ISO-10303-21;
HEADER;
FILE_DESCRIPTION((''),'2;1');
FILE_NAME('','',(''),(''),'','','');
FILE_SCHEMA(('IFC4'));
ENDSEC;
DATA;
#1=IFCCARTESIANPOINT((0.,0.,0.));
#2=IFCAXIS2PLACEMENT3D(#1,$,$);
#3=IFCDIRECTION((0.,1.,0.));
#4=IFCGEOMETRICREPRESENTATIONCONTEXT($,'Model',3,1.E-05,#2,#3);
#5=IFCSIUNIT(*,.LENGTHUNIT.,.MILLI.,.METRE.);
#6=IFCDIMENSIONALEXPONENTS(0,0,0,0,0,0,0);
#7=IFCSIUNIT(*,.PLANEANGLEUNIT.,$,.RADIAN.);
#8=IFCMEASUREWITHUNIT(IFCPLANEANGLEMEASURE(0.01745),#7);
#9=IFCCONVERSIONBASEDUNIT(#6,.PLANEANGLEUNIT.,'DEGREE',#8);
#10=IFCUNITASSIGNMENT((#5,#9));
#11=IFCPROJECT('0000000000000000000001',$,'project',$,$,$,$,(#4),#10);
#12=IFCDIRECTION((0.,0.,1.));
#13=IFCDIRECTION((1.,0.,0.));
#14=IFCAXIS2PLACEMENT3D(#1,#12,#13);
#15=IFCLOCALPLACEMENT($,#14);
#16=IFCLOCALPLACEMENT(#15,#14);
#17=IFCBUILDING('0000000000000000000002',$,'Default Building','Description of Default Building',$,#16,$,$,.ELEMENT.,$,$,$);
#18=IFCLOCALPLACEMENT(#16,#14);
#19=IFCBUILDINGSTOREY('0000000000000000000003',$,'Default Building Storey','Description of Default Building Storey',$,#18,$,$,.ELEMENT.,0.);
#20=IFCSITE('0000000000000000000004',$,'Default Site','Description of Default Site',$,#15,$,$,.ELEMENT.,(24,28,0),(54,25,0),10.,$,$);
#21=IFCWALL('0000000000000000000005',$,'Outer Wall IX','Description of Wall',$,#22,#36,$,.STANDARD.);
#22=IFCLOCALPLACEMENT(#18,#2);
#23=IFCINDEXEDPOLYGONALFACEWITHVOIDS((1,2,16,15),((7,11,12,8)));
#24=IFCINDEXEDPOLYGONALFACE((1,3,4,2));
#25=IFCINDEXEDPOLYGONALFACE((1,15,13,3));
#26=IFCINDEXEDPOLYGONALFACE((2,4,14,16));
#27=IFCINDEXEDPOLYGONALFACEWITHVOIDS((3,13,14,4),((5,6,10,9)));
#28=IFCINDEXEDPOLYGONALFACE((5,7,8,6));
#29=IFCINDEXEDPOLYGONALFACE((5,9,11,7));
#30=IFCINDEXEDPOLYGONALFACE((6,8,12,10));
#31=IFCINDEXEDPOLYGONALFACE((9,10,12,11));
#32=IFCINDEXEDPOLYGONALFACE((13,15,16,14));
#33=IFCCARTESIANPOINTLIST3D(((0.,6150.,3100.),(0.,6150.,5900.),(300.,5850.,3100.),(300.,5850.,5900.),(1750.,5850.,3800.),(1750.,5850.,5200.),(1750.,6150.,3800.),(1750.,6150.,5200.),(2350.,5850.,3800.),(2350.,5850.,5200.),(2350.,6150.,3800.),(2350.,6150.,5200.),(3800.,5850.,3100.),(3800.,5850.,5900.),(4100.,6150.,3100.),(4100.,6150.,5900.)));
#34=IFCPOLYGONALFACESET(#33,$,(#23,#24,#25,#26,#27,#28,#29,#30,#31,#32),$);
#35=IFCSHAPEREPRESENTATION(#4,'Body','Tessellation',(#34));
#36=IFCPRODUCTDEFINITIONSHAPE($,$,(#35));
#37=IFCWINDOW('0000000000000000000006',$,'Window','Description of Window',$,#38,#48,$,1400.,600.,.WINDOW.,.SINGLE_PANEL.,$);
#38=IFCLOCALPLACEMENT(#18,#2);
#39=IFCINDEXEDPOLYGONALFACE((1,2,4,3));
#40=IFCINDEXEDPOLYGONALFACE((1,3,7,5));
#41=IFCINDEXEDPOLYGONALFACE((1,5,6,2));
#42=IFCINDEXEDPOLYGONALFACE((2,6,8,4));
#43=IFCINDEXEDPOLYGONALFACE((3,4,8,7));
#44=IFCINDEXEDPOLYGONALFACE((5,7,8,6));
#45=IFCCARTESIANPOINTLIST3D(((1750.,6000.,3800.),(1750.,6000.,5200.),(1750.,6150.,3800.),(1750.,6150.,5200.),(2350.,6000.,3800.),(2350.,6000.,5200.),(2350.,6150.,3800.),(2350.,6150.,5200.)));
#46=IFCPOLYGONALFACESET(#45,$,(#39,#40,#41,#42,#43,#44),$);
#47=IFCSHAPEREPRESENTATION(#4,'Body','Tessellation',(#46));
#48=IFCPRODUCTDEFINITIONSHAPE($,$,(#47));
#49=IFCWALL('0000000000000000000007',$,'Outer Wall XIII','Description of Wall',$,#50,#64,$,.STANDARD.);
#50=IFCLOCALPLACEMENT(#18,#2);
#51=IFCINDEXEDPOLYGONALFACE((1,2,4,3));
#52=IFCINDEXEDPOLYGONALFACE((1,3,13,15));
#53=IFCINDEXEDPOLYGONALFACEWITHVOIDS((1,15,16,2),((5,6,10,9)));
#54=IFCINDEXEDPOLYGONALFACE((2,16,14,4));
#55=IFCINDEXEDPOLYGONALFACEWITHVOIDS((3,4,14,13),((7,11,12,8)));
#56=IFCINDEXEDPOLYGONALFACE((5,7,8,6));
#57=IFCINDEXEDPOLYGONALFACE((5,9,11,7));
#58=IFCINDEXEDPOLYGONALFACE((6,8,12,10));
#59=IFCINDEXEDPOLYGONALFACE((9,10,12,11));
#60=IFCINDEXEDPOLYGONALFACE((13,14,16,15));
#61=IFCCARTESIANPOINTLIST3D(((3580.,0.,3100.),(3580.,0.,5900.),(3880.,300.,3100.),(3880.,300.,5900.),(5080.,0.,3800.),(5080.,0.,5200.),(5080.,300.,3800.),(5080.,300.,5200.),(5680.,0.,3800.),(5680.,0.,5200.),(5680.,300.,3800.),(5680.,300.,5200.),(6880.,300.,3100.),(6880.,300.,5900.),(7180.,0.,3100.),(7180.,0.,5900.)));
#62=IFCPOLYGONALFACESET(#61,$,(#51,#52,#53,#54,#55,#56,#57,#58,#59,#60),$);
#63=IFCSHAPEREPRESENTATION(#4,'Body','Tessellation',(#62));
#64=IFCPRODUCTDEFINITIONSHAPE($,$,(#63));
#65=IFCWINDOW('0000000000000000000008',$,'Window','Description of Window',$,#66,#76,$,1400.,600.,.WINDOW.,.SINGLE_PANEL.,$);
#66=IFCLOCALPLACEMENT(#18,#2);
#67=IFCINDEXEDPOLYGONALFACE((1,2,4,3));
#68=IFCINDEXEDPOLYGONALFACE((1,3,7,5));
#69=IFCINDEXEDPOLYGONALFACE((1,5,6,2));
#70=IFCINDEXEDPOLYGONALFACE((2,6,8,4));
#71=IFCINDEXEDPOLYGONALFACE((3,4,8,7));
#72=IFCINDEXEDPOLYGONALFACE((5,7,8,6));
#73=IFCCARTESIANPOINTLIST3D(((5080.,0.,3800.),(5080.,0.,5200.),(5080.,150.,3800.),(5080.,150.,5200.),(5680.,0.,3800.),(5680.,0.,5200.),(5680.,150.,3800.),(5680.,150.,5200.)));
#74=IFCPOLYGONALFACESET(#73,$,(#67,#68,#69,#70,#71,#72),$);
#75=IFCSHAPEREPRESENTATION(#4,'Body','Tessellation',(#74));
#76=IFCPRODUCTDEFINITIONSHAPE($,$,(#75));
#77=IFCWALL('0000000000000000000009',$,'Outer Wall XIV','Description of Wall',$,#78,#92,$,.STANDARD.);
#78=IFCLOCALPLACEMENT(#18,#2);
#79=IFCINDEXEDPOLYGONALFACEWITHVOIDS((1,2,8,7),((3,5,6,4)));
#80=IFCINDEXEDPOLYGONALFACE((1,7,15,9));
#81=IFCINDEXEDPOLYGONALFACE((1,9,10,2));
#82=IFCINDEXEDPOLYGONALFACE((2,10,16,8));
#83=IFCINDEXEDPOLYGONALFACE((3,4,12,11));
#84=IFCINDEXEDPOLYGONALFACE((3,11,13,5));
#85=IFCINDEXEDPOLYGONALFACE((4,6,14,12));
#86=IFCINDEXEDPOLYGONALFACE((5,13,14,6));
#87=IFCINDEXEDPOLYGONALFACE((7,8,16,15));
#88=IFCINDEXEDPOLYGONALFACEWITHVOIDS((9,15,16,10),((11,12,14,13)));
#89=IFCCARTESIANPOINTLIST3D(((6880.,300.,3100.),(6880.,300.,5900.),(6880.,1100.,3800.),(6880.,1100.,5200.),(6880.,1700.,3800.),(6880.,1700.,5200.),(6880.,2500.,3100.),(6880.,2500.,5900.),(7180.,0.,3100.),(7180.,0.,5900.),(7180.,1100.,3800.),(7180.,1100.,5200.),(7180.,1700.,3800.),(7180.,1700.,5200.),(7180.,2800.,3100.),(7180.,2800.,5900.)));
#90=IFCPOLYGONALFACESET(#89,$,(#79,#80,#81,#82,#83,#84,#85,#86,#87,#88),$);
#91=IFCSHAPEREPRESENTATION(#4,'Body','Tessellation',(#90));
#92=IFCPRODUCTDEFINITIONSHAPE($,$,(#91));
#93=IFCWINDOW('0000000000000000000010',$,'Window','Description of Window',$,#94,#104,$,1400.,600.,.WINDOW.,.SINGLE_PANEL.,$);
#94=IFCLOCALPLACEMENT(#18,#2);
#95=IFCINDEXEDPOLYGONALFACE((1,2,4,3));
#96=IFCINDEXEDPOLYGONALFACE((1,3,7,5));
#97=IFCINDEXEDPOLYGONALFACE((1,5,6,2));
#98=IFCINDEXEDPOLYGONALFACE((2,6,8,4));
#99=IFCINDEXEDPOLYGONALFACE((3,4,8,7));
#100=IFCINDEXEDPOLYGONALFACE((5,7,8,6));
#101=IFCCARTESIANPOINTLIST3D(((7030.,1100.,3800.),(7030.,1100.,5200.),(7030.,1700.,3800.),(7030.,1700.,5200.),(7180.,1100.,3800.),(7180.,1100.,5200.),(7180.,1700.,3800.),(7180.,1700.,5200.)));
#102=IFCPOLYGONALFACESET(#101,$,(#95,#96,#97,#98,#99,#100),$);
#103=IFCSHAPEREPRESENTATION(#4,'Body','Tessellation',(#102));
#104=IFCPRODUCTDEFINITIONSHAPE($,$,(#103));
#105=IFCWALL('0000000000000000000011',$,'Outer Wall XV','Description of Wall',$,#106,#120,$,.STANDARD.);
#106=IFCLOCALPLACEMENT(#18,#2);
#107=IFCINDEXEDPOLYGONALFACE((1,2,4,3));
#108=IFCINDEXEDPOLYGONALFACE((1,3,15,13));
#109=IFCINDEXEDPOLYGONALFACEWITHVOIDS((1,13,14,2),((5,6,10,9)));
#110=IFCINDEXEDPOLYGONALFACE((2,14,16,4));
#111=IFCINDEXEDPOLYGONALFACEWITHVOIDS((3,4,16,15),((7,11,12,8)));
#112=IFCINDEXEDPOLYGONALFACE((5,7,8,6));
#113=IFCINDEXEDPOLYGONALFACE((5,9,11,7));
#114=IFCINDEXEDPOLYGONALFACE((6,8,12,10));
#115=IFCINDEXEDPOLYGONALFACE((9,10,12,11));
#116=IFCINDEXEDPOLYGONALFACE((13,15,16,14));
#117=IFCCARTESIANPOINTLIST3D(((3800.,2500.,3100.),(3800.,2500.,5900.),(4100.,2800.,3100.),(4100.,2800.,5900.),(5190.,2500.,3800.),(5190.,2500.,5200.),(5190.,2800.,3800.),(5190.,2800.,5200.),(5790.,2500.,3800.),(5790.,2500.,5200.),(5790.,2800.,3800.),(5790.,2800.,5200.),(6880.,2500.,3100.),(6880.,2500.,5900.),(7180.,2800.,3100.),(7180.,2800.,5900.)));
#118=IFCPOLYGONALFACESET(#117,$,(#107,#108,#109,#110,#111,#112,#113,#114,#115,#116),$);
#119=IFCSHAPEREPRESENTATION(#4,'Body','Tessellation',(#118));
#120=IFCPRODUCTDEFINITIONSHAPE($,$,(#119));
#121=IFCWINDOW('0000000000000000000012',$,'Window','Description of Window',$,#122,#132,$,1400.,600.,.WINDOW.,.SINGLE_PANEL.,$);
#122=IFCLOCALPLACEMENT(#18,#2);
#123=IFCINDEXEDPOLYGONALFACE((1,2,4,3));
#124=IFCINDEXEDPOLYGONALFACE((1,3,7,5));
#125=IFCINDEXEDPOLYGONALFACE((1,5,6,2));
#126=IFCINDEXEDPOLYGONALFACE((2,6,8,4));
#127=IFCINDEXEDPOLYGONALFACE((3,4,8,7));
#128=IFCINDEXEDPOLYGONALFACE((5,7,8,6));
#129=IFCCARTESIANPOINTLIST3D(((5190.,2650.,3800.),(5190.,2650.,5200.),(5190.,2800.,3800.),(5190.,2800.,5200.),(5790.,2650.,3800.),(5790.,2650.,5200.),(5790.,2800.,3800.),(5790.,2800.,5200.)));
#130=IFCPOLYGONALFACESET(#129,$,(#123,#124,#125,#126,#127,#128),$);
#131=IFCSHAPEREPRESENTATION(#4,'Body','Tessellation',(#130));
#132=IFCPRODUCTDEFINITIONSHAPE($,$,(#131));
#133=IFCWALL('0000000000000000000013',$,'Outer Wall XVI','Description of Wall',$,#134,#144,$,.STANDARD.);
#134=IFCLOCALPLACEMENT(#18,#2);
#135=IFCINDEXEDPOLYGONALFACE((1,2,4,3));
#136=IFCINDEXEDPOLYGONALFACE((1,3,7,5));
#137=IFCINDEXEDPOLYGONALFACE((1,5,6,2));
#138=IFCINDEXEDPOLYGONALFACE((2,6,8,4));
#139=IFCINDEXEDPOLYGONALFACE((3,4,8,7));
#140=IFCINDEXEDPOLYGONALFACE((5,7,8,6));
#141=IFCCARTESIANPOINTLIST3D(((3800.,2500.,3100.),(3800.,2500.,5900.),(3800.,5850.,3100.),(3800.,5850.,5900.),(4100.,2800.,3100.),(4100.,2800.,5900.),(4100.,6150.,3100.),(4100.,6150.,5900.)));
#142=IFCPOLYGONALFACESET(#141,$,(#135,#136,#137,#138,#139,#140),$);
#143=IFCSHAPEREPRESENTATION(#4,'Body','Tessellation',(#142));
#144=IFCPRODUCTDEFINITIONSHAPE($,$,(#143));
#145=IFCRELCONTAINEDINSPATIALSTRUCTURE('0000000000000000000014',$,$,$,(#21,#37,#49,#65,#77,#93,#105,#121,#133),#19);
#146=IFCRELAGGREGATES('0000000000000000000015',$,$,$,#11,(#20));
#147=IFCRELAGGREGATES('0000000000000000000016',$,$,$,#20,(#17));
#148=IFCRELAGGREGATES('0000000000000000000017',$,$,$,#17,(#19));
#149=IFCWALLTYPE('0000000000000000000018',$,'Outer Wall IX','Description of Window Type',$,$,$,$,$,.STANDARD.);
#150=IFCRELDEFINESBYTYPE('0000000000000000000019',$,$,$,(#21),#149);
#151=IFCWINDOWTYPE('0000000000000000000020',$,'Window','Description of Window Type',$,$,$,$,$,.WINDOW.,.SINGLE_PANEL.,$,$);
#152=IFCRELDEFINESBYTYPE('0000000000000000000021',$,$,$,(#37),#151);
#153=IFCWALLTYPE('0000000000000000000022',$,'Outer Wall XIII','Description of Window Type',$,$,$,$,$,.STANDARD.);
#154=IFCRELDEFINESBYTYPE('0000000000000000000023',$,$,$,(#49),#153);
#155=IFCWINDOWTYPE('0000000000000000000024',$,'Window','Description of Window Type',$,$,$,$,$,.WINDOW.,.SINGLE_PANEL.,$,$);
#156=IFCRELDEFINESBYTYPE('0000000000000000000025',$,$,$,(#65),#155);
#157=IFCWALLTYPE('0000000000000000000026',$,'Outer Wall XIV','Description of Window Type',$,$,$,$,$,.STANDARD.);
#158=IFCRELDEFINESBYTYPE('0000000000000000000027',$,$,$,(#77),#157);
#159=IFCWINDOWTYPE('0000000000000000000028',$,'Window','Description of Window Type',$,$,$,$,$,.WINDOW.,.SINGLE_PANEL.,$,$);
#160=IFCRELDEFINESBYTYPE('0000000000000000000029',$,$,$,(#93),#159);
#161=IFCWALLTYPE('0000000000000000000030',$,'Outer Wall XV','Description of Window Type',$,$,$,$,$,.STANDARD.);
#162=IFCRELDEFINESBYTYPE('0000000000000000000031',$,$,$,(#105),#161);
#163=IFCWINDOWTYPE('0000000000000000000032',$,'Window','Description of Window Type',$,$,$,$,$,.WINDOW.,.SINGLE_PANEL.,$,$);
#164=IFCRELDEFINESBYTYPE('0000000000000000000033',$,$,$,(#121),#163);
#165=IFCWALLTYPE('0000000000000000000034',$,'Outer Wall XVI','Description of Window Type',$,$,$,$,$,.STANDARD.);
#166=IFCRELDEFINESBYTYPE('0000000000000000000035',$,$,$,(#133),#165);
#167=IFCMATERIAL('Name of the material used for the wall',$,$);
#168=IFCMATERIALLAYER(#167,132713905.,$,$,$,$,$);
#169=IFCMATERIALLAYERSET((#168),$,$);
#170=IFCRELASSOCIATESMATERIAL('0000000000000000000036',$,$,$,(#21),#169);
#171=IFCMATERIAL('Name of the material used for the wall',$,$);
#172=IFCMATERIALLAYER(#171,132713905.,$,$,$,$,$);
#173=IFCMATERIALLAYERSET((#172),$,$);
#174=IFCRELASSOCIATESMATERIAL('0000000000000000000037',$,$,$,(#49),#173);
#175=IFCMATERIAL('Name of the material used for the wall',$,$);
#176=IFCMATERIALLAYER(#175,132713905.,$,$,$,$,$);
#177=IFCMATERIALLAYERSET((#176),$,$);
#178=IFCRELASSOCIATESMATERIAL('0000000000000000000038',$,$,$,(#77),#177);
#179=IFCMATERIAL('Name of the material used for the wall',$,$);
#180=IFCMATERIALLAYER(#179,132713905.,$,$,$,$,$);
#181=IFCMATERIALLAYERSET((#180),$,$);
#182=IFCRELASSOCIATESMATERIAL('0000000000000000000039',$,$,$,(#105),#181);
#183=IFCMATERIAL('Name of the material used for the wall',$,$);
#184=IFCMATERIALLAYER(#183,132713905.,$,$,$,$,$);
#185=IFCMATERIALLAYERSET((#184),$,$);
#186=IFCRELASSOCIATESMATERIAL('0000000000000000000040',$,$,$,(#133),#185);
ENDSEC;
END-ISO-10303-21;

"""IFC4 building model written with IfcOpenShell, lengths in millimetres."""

from ifc_helpers import new_model, entity, si_unit, converted_unit, direction, frame, origin, origin_with_axes, place, context, project, spatial, polyline, outline, extrude, material, layer, layer_set, layer_usage, type_object, element, fill, save


model = new_model("IFC4")

# Units and contexts
model_context = context("Model", 3, precision=1e-05, world=origin(), true_north=direction((0.0, 1.0, 0.0)))
ifc_project = project(units=[si_unit("LENGTHUNIT", "METRE", prefix="MILLI"), converted_unit("PLANEANGLEUNIT", "DEGREE", entity("IfcPlaneAngleMeasure", 0.01745), si_unit("PLANEANGLEUNIT", "RADIAN"), dimensions=[0, 0, 0, 0, 0, 0, 0])], contexts=[model_context])

# Site, building, storey
site_placement = place(None, origin_with_axes())
site = spatial("IfcSite", under=ifc_project, at=site_placement, Name="Default Site", Description="Description of Default Site", CompositionType="ELEMENT", RefLatitude=(24, 28, 0), RefLongitude=(54, 25, 0), RefElevation=10.0)
building_placement = place(site_placement, origin_with_axes())
building = spatial("IfcBuilding", under=site, at=building_placement, Name="Default Building", Description="Description of Default Building", CompositionType="ELEMENT")
storey_placement = place(building_placement, origin_with_axes())
storey = spatial("IfcBuildingStorey", under=building, at=storey_placement, Name="Default Building Storey", Description="Description of Default Building Storey", CompositionType="ELEMENT", Elevation=0.0)

# Walls, openings, windows
ifc_material_1 = material(Name="Name of the material used for the wall")
ifc_layer_1 = layer(ifc_material_1, 132713905.0)
ifc_layer_set_1 = layer_set([ifc_layer_1])
ifc_layer_usage_1 = layer_usage(ifc_layer_set_1, "AXIS2", "POSITIVE", -66356952.5)
wall_type_1 = type_object("IfcWallType", Name="Outer Wall IX", Description="Description of Window Type", PredefinedType="STANDARD")
wall_1_placement = place(storey_placement, frame((3950.0, 6000.0, 3100.0), z_axis=(0.0, 0.0, 1.0), x_axis=(-1.0, 0.0, 0.0)))
wall_1 = element("IfcWall", 1, at=wall_1_placement, inside=storey, type_object=wall_type_1, material=ifc_layer_usage_1, Name="Outer Wall IX", Description="Description of Wall", PredefinedType="STANDARD", context=model_context, shape_type="SweptSolid", body=[
    extrude(outline(polyline([(-150.0, -150.0), (150.0, 150.0), (3650.0, 150.0), (3950.0, -150.0), (-150.0, -150.0)])), origin_with_axes(), (0.0, 0.0, 1.0), 2800.0),
])
opening_1_placement = place(wall_1_placement, frame((1600.0, -150.0, 700.0), z_axis=(0.0, 0.0, 1.0), x_axis=(1.0, 0.0, 0.0)))
opening_1 = element("IfcOpeningElement", 2, at=opening_1_placement, cuts=wall_1, context=model_context, shape_type="SweptSolid", body=[
    extrude(outline(polyline([(0.0, 0.0), (0.0, 300.0), (600.0, 300.0), (600.0, 0.0), (0.0, 0.0)])), origin_with_axes(), (0.0, 0.0, 1.0), 1400.0),
])
window_type_1 = type_object("IfcWindowType", Name="Window", Description="Description of Window Type", PartitioningType="SINGLE_PANEL", PredefinedType="WINDOW")
window_1_placement = place(opening_1_placement, origin_with_axes())
window_1 = element("IfcWindow", 3, at=window_1_placement, inside=storey, type_object=window_type_1, Name="Window", Description="Description of Window", OverallHeight=1400.0, OverallWidth=600.0, PartitioningType="SINGLE_PANEL", PredefinedType="WINDOW", context=model_context, shape_type="SweptSolid", body=[
    extrude(outline(polyline([(0.0, 0.0), (0.0, 150.0), (600.0, 150.0), (600.0, 0.0), (0.0, 0.0)])), origin_with_axes(), (0.0, 0.0, 1.0), 1400.0),
])
fill(opening_1, window_1)
ifc_material_2 = material(Name="Name of the material used for the wall")
ifc_layer_2 = layer(ifc_material_2, 132713905.0)
ifc_layer_set_2 = layer_set([ifc_layer_2])
ifc_layer_usage_2 = layer_usage(ifc_layer_set_2, "AXIS2", "POSITIVE", -66356952.5)
wall_type_2 = type_object("IfcWallType", Name="Outer Wall XIII", Description="Description of Window Type", PredefinedType="STANDARD")
wall_2_placement = place(storey_placement, frame((3730.0, 150.0, 3100.0), z_axis=(0.0, 0.0, 1.0), x_axis=(1.0, 0.0, 0.0)))
wall_2 = element("IfcWall", 4, at=wall_2_placement, inside=storey, type_object=wall_type_2, material=ifc_layer_usage_2, Name="Outer Wall XIII", Description="Description of Wall", PredefinedType="STANDARD", context=model_context, shape_type="SweptSolid", body=[
    extrude(outline(polyline([(-150.0, -150.0), (150.0, 150.0), (3150.0, 150.0), (3450.0, -150.0), (-150.0, -150.0)])), origin_with_axes(), (0.0, 0.0, 1.0), 2800.0),
])
opening_2_placement = place(wall_2_placement, frame((1350.0, -150.0, 700.0), z_axis=(0.0, 0.0, 1.0), x_axis=(1.0, 0.0, 0.0)))
opening_2 = element("IfcOpeningElement", 5, at=opening_2_placement, cuts=wall_2, context=model_context, shape_type="SweptSolid", body=[
    extrude(outline(polyline([(0.0, 0.0), (0.0, 300.0), (600.0, 300.0), (600.0, 0.0), (0.0, 0.0)])), origin_with_axes(), (0.0, 0.0, 1.0), 1400.0),
])
window_type_2 = type_object("IfcWindowType", Name="Window", Description="Description of Window Type", PartitioningType="SINGLE_PANEL", PredefinedType="WINDOW")
window_2_placement = place(opening_2_placement, origin_with_axes())
window_2 = element("IfcWindow", 6, at=window_2_placement, inside=storey, type_object=window_type_2, Name="Window", Description="Description of Window", OverallHeight=1400.0, OverallWidth=600.0, PartitioningType="SINGLE_PANEL", PredefinedType="WINDOW", context=model_context, shape_type="SweptSolid", body=[
    extrude(outline(polyline([(0.0, 0.0), (0.0, 150.0), (600.0, 150.0), (600.0, 0.0), (0.0, 0.0)])), origin_with_axes(), (0.0, 0.0, 1.0), 1400.0),
])
fill(opening_2, window_2)
ifc_material_3 = material(Name="Name of the material used for the wall")
ifc_layer_3 = layer(ifc_material_3, 132713905.0)
ifc_layer_set_3 = layer_set([ifc_layer_3])
ifc_layer_usage_3 = layer_usage(ifc_layer_set_3, "AXIS2", "POSITIVE", -66356952.5)
wall_type_3 = type_object("IfcWallType", Name="Outer Wall XIV", Description="Description of Window Type", PredefinedType="STANDARD")
wall_3_placement = place(storey_placement, frame((7030.0, 150.0, 3100.0), z_axis=(0.0, 0.0, 1.0), x_axis=(0.0, 1.0, 0.0)))
wall_3 = element("IfcWall", 7, at=wall_3_placement, inside=storey, type_object=wall_type_3, material=ifc_layer_usage_3, Name="Outer Wall XIV", Description="Description of Wall", PredefinedType="STANDARD", context=model_context, shape_type="SweptSolid", body=[
    extrude(outline(polyline([(-150.0, -150.0), (150.0, 150.0), (2350.0, 150.0), (2650.0, -150.0), (-150.0, -150.0)])), origin_with_axes(), (0.0, 0.0, 1.0), 2800.0),
])
opening_3_placement = place(wall_3_placement, frame((950.0, -150.0, 700.0), z_axis=(0.0, 0.0, 1.0), x_axis=(1.0, 0.0, 0.0)))
opening_3 = element("IfcOpeningElement", 8, at=opening_3_placement, cuts=wall_3, context=model_context, shape_type="SweptSolid", body=[
    extrude(outline(polyline([(0.0, 0.0), (0.0, 300.0), (600.0, 300.0), (600.0, 0.0), (0.0, 0.0)])), origin_with_axes(), (0.0, 0.0, 1.0), 1400.0),
])
window_type_3 = type_object("IfcWindowType", Name="Window", Description="Description of Window Type", PartitioningType="SINGLE_PANEL", PredefinedType="WINDOW")
window_3_placement = place(opening_3_placement, origin_with_axes())
window_3 = element("IfcWindow", 9, at=window_3_placement, inside=storey, type_object=window_type_3, Name="Window", Description="Description of Window", OverallHeight=1400.0, OverallWidth=600.0, PartitioningType="SINGLE_PANEL", PredefinedType="WINDOW", context=model_context, shape_type="SweptSolid", body=[
    extrude(outline(polyline([(0.0, 0.0), (0.0, 150.0), (600.0, 150.0), (600.0, 0.0), (0.0, 0.0)])), origin_with_axes(), (0.0, 0.0, 1.0), 1400.0),
])
fill(opening_3, window_3)
ifc_material_4 = material(Name="Name of the material used for the wall")
ifc_layer_4 = layer(ifc_material_4, 132713905.0)
ifc_layer_set_4 = layer_set([ifc_layer_4])
ifc_layer_usage_4 = layer_usage(ifc_layer_set_4, "AXIS2", "POSITIVE", -66356952.5)
wall_type_4 = type_object("IfcWallType", Name="Outer Wall XV", Description="Description of Window Type", PredefinedType="STANDARD")
wall_4_placement = place(storey_placement, frame((7030.0, 2650.0, 3100.0), z_axis=(0.0, 0.0, 1.0), x_axis=(-1.0, 0.0, 0.0)))
wall_4 = element("IfcWall", 10, at=wall_4_placement, inside=storey, type_object=wall_type_4, material=ifc_layer_usage_4, Name="Outer Wall XV", Description="Description of Wall", PredefinedType="STANDARD", context=model_context, shape_type="SweptSolid", body=[
    extrude(outline(polyline([(-150.0, -150.0), (150.0, 150.0), (3230.0, 150.0), (2930.0, -150.0), (-150.0, -150.0)])), origin_with_axes(), (0.0, 0.0, 1.0), 2800.0),
])
opening_4_placement = place(wall_4_placement, frame((1240.0, -150.0, 700.0), z_axis=(0.0, 0.0, 1.0), x_axis=(1.0, 0.0, 0.0)))
opening_4 = element("IfcOpeningElement", 11, at=opening_4_placement, cuts=wall_4, context=model_context, shape_type="SweptSolid", body=[
    extrude(outline(polyline([(0.0, 0.0), (0.0, 300.0), (600.0, 300.0), (600.0, 0.0), (0.0, 0.0)])), origin_with_axes(), (0.0, 0.0, 1.0), 1400.0),
])
window_type_4 = type_object("IfcWindowType", Name="Window", Description="Description of Window Type", PartitioningType="SINGLE_PANEL", PredefinedType="WINDOW")
window_4_placement = place(opening_4_placement, origin_with_axes())
window_4 = element("IfcWindow", 12, at=window_4_placement, inside=storey, type_object=window_type_4, Name="Window", Description="Description of Window", OverallHeight=1400.0, OverallWidth=600.0, PartitioningType="SINGLE_PANEL", PredefinedType="WINDOW", context=model_context, shape_type="SweptSolid", body=[
    extrude(outline(polyline([(0.0, 0.0), (0.0, 150.0), (600.0, 150.0), (600.0, 0.0), (0.0, 0.0)])), origin_with_axes(), (0.0, 0.0, 1.0), 1400.0),
])
fill(opening_4, window_4)

# Wall
ifc_material_5 = material(Name="Name of the material used for the wall")
ifc_layer_5 = layer(ifc_material_5, 132713905.0)
ifc_layer_set_5 = layer_set([ifc_layer_5])
ifc_layer_usage_5 = layer_usage(ifc_layer_set_5, "AXIS2", "POSITIVE", -66356952.5)
wall_type_5 = type_object("IfcWallType", Name="Outer Wall XVI", Description="Description of Window Type", PredefinedType="STANDARD")
wall_5_placement = place(storey_placement, frame((3950.0, 2650.0, 3100.0), z_axis=(0.0, 0.0, 1.0), x_axis=(0.0, 1.0, 0.0)))
element("IfcWall", 13, at=wall_5_placement, inside=storey, type_object=wall_type_5, material=ifc_layer_usage_5, Name="Outer Wall XVI", Description="Description of Wall", PredefinedType="STANDARD", context=model_context, shape_type="SweptSolid", body=[
    extrude(outline(polyline([(150.0, -150.0), (-150.0, 150.0), (3200.0, 150.0), (3500.0, -150.0), (150.0, -150.0)])), origin_with_axes(), (0.0, 0.0, 1.0), 2800.0),
])

save(model, "model.ifc")
